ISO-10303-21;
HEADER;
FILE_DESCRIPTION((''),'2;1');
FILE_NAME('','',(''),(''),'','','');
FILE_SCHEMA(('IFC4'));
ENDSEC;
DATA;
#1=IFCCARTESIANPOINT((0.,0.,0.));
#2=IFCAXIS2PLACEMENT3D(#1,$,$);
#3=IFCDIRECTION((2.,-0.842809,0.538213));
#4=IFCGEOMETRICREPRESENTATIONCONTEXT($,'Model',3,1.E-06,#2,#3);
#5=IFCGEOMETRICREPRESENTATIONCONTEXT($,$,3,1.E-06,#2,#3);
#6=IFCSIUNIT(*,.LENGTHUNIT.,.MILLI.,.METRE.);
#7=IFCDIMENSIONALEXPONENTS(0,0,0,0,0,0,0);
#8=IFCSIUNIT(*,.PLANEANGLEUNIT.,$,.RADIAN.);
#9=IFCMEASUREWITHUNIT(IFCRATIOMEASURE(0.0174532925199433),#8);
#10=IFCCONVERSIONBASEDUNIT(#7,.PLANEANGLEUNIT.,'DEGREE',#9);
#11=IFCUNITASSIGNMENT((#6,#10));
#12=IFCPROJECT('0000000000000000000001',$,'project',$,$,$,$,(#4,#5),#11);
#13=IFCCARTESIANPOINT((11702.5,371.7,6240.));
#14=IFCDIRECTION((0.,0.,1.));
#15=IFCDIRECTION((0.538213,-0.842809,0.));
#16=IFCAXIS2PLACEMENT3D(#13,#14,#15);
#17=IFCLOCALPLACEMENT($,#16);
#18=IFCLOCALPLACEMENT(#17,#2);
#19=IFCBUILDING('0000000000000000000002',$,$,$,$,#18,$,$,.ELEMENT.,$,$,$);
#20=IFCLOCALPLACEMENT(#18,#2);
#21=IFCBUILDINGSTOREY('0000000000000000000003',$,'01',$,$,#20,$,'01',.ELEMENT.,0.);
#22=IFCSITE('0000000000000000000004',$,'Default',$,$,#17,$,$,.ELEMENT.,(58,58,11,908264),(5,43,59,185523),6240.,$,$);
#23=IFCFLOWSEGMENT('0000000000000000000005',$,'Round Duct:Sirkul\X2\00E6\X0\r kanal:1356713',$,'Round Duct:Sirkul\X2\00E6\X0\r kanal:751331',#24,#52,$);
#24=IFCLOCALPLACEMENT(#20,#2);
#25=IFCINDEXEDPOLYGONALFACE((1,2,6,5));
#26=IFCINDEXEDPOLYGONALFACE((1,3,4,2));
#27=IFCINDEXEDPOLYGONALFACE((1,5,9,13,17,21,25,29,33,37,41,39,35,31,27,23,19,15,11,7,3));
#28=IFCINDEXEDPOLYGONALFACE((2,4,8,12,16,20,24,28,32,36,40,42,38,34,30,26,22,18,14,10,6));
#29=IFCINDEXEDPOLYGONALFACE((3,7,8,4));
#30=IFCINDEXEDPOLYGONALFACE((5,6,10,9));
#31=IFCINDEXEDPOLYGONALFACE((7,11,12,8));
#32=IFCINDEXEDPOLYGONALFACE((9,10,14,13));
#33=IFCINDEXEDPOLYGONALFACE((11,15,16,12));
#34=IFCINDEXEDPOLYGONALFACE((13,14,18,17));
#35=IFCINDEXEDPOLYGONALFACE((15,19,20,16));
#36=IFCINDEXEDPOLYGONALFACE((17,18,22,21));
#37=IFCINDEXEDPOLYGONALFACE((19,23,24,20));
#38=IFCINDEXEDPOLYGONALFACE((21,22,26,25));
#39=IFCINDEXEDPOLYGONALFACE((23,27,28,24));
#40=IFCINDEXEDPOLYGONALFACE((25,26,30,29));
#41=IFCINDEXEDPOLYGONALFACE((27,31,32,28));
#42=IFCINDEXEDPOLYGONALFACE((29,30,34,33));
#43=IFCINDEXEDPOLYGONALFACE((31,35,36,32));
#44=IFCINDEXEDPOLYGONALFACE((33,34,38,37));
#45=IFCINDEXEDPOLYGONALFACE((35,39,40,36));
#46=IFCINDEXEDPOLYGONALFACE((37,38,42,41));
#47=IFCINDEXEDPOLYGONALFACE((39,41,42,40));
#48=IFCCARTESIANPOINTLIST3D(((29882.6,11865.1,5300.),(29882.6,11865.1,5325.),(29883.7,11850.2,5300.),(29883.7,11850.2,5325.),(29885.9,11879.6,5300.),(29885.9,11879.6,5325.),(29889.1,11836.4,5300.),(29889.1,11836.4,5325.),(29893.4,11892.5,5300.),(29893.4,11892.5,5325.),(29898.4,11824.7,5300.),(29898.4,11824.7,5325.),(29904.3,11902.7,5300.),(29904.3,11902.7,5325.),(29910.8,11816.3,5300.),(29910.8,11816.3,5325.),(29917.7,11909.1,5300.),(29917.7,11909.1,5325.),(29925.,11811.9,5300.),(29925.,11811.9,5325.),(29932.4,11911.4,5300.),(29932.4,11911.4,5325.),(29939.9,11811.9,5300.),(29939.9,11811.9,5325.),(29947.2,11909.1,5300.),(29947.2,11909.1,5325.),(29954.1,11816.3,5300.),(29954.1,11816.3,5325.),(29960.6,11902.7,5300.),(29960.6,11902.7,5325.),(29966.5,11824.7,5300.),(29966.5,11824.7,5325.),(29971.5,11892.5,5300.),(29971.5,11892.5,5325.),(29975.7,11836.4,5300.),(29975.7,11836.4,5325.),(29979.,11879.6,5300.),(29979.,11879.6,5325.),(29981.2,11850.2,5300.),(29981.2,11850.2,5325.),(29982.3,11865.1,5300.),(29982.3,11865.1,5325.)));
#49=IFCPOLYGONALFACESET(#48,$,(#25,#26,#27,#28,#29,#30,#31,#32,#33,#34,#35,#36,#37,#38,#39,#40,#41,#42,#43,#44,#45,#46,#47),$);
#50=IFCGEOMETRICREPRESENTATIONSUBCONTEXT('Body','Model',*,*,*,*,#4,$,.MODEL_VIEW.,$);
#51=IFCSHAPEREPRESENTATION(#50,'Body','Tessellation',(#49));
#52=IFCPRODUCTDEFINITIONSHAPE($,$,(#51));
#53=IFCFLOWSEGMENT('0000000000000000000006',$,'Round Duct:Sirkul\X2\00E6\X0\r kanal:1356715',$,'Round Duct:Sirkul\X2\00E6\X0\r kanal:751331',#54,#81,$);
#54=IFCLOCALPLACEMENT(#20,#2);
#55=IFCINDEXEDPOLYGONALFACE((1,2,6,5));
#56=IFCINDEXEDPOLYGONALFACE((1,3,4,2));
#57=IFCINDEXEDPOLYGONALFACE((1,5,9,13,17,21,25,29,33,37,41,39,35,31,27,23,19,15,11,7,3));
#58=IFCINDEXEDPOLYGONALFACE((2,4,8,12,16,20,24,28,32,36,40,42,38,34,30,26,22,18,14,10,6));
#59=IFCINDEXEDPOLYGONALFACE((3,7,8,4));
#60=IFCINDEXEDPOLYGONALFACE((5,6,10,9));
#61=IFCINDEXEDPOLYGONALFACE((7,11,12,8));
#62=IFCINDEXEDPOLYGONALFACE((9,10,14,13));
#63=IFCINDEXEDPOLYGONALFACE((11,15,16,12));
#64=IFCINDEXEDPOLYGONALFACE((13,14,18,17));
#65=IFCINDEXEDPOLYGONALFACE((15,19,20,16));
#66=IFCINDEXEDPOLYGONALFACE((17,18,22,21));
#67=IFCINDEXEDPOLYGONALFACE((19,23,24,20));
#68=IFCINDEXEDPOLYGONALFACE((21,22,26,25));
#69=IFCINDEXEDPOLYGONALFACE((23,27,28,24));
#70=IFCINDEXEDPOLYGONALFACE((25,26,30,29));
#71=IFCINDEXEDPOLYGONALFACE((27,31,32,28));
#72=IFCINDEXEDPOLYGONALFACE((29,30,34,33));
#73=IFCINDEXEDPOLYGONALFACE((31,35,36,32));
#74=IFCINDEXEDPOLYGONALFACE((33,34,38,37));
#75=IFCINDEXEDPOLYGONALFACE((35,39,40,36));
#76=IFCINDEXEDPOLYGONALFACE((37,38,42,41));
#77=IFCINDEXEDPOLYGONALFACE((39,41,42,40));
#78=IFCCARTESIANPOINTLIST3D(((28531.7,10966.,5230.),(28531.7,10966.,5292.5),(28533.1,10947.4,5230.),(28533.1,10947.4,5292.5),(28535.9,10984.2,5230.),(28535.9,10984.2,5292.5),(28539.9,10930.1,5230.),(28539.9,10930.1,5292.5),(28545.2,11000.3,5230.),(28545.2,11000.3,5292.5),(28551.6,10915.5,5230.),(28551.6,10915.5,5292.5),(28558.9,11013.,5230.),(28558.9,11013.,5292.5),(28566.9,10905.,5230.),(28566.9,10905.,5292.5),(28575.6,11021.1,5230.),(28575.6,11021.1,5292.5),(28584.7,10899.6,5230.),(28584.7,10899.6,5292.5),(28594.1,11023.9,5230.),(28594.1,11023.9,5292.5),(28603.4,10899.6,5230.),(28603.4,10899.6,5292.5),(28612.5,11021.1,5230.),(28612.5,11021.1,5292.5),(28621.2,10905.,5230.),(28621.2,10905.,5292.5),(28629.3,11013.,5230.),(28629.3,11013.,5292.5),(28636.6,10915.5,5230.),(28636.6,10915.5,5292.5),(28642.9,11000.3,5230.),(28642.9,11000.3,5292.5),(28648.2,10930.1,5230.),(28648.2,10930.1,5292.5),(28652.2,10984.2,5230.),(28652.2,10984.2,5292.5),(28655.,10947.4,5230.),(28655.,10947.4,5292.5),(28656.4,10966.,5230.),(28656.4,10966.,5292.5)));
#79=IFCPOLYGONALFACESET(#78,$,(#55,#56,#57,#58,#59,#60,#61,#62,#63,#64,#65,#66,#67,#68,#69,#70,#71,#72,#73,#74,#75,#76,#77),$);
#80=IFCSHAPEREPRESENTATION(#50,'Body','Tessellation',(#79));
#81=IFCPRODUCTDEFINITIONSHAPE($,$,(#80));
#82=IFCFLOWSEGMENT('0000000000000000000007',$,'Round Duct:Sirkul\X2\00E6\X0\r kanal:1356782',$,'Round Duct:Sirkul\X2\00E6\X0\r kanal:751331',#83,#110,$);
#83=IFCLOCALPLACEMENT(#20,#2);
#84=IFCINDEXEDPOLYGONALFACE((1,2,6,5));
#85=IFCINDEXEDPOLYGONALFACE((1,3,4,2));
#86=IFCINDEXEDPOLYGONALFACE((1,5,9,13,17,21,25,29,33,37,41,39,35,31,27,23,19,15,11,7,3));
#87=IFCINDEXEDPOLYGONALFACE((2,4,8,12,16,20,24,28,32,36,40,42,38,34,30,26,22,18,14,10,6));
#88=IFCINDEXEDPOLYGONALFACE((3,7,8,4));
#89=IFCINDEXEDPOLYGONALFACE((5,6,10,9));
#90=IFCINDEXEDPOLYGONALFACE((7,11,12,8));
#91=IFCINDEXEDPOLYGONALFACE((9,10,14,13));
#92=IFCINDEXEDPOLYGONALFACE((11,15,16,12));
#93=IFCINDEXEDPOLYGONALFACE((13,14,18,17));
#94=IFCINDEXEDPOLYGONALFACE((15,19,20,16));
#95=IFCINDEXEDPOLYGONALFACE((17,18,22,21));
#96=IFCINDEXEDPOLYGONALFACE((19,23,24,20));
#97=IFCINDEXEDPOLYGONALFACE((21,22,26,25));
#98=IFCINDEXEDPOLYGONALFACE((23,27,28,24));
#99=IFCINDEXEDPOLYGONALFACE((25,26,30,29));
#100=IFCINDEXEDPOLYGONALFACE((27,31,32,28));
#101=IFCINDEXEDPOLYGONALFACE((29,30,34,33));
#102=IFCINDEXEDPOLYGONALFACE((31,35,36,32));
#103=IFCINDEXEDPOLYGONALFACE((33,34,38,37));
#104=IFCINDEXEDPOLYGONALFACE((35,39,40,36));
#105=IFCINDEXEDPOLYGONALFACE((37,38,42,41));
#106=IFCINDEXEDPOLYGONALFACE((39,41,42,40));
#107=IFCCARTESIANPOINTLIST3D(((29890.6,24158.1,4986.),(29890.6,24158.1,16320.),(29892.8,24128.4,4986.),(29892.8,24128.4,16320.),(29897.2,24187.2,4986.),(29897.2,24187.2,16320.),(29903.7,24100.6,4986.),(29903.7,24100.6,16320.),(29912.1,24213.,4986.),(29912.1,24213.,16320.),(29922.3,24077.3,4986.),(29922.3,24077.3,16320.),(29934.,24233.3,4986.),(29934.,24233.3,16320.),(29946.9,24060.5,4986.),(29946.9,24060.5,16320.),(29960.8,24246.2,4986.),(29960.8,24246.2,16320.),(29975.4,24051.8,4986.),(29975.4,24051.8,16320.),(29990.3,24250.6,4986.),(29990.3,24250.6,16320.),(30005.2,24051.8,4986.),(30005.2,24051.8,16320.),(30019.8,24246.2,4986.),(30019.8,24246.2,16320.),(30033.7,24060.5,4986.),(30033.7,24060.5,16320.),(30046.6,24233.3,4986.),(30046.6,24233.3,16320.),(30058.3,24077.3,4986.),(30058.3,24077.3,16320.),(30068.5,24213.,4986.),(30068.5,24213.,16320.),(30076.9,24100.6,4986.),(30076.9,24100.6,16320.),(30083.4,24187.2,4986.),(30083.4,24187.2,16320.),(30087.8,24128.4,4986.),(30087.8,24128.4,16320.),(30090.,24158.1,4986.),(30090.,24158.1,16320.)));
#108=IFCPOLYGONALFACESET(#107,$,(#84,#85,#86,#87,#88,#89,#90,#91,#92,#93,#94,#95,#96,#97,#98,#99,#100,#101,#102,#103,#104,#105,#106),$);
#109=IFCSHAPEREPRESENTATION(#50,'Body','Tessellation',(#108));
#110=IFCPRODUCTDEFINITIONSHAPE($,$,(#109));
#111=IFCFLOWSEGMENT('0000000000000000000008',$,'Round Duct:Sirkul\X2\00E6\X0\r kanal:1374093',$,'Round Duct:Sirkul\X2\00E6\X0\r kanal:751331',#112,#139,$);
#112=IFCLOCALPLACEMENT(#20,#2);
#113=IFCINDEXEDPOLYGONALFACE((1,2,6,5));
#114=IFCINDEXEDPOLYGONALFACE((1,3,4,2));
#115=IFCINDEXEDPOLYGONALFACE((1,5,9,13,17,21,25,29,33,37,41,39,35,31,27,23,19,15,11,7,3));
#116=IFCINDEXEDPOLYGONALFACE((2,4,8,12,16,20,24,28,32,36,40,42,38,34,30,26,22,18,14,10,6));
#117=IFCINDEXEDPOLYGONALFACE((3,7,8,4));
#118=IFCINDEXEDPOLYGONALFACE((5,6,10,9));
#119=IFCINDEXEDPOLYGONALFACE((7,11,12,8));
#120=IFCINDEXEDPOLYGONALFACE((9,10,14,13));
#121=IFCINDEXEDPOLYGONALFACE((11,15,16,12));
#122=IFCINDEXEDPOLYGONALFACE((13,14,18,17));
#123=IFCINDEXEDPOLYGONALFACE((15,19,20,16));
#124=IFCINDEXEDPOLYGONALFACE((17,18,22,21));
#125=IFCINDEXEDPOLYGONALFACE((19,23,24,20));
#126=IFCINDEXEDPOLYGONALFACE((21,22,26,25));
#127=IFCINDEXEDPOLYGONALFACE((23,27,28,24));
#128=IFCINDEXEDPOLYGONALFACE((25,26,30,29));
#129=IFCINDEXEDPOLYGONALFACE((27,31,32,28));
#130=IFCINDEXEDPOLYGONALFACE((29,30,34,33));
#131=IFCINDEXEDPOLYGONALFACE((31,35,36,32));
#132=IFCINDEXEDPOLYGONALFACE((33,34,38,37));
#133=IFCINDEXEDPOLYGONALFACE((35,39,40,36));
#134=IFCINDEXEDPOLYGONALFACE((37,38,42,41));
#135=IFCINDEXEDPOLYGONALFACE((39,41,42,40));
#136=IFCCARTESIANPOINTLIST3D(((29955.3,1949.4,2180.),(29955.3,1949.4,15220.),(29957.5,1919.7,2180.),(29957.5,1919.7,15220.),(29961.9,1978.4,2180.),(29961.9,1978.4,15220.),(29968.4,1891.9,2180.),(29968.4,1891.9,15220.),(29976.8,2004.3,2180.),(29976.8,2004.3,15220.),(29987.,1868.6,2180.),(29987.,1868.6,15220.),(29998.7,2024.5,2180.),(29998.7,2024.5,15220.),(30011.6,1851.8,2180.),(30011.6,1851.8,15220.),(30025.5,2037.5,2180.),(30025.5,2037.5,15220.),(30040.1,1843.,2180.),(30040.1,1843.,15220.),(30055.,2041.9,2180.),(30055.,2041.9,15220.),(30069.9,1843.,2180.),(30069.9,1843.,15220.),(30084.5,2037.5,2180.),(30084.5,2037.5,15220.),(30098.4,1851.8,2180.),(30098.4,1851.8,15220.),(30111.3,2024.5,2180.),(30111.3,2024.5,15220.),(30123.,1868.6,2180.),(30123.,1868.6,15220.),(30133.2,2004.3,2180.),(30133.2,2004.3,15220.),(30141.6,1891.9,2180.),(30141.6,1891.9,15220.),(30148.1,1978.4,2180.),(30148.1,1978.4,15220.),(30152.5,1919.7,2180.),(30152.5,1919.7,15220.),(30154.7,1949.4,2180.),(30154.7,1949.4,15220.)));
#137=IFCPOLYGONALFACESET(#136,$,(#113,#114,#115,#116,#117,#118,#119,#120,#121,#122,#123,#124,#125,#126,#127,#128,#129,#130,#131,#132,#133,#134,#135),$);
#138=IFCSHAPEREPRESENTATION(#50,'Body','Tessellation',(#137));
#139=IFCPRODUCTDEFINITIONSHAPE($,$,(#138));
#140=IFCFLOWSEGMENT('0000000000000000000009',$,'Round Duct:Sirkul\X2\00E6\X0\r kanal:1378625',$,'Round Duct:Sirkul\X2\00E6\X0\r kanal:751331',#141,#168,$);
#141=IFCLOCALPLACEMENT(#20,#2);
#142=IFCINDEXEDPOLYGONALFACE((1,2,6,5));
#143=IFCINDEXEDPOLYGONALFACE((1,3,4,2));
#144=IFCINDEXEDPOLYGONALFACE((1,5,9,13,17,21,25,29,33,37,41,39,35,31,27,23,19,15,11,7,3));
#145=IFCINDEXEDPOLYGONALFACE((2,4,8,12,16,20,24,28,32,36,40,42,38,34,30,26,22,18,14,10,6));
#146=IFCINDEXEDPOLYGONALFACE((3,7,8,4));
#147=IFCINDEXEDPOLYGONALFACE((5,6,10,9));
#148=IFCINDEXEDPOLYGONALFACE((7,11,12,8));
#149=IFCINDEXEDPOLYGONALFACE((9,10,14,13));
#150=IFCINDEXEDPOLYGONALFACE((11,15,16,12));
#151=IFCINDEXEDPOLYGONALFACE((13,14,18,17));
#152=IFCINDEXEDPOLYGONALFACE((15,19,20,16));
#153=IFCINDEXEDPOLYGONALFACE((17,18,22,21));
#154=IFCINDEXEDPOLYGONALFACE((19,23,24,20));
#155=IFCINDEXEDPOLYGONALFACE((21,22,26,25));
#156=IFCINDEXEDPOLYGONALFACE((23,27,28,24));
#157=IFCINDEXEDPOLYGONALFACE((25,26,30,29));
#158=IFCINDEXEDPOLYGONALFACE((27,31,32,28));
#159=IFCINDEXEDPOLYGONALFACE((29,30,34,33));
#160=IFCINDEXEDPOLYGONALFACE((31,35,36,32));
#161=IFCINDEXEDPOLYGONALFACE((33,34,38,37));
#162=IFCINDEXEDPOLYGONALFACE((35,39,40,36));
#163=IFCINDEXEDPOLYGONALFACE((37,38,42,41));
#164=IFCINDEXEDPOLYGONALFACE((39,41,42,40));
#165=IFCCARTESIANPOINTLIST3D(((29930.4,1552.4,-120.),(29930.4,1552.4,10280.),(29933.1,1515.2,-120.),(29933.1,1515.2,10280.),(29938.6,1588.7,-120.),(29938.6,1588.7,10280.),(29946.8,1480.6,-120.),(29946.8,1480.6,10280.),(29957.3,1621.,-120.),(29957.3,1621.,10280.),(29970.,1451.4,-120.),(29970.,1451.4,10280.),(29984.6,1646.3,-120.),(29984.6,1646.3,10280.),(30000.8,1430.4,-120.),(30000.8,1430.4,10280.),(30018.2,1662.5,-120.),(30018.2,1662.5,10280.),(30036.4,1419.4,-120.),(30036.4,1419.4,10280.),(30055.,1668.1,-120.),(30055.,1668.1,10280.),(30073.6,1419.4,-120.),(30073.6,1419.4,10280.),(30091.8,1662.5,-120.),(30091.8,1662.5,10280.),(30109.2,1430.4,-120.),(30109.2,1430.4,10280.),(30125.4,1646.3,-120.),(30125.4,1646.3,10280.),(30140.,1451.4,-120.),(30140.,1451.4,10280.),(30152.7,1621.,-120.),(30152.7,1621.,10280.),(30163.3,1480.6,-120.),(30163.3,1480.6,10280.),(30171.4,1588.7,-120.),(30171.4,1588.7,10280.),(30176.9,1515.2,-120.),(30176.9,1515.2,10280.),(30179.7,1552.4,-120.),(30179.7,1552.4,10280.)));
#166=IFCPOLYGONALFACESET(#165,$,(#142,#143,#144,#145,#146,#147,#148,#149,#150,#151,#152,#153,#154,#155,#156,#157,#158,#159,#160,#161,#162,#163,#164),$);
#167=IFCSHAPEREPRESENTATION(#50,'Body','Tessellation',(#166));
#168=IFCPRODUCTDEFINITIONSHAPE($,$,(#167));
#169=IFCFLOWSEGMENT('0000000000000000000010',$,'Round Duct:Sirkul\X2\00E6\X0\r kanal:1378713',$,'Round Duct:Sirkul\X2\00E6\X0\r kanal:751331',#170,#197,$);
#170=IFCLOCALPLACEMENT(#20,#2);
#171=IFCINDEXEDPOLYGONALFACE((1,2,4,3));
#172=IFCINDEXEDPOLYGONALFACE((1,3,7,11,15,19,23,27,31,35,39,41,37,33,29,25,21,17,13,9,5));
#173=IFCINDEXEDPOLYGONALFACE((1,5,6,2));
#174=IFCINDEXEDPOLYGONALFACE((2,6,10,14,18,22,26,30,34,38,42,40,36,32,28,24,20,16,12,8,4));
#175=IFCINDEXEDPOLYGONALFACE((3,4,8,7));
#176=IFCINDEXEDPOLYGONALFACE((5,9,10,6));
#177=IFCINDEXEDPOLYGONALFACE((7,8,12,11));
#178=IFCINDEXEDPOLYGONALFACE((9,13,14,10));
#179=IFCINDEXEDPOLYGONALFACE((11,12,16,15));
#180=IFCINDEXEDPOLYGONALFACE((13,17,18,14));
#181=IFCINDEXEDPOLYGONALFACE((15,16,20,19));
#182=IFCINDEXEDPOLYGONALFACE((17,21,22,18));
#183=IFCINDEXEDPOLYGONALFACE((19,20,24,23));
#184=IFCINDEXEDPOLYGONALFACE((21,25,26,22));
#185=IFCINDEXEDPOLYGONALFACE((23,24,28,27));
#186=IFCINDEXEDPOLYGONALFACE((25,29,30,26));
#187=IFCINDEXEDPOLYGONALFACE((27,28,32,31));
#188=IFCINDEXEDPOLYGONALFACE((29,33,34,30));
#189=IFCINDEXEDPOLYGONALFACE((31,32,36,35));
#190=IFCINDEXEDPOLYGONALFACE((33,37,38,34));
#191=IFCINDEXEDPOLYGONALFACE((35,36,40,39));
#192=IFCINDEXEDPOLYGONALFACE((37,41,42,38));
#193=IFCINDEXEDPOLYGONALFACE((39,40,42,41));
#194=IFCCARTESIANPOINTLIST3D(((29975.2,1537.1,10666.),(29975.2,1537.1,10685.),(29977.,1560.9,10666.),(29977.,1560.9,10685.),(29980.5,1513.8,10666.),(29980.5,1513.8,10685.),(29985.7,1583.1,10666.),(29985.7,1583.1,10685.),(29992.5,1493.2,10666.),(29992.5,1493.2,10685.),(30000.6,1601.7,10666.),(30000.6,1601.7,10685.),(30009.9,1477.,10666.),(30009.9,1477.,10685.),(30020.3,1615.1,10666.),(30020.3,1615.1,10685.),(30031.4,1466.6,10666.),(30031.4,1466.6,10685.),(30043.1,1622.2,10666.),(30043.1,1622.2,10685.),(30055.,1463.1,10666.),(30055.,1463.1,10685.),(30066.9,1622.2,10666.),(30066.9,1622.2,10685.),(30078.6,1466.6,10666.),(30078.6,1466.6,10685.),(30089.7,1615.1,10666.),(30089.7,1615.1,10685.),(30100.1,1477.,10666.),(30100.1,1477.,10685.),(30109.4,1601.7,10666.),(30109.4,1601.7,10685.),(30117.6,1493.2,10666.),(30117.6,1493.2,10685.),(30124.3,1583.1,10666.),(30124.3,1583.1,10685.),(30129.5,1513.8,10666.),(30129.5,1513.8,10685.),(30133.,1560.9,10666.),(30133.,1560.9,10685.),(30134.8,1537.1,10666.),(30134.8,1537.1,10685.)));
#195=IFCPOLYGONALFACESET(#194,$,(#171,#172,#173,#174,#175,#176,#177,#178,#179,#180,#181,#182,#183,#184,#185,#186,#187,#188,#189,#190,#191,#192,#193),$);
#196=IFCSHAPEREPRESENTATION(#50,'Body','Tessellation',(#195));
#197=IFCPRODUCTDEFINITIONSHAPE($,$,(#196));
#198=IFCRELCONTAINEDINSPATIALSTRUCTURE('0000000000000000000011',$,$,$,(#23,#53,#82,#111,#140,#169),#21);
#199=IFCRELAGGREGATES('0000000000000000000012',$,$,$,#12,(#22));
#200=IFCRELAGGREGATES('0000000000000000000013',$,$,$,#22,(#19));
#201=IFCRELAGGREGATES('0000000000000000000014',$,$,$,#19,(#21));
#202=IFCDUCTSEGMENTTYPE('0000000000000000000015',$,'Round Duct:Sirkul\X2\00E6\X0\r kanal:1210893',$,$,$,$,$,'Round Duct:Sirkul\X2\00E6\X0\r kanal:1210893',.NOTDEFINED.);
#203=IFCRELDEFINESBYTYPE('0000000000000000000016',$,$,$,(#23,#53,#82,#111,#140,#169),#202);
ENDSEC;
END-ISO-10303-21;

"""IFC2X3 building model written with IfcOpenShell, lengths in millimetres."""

from ifc_helpers import new_model, entity, si_unit, converted_unit, direction, frame, frame_2d, origin, origin_2d_with_axis, place, context, subcontext, project, spatial, circle, extrude, type_object, element, save


model = new_model("IFC2X3")

# Units and contexts
model_context = context("Model", 3, precision=1e-06, world=origin(), true_north=direction((2.0, -0.842809, 0.538213)))
context_of_model = context(None, 3, precision=1e-06, world=origin(), true_north=direction((2.0, -0.842809, 0.538213)))
body_context = subcontext(model_context, "Body", "Model", "MODEL_VIEW")
ifc_project = project(units=[si_unit("LENGTHUNIT", "METRE", prefix="MILLI"), converted_unit("PLANEANGLEUNIT", "DEGREE", entity("IfcRatioMeasure", 0.0174532925199433), si_unit("PLANEANGLEUNIT", "RADIAN"), dimensions=[0, 0, 0, 0, 0, 0, 0])], contexts=[model_context, context_of_model])

# Site, building, storey
site_placement = place(None, frame((11702.5, 371.7, 6240.0), z_axis=(0.0, 0.0, 1.0), x_axis=(0.538213, -0.842809, 0.0)))
site = spatial("IfcSite", under=ifc_project, at=site_placement, Name="Default", CompositionType="ELEMENT", RefLatitude=(58, 58, 11, 908264), RefLongitude=(5, 43, 59, 185523), RefElevation=6240.0)
building_placement = place(site_placement, origin())
building = spatial("IfcBuilding", under=site, at=building_placement, CompositionType="ELEMENT")
storey_placement = place(building_placement, origin())
storey = spatial("IfcBuildingStorey", under=building, at=storey_placement, Name="01", LongName="01", CompositionType="ELEMENT", Elevation=0.0)

# Flow segments
duct_segment_type = type_object("IfcDuctSegmentType", Name="Round Duct:Sirkulær kanal:1210893", ElementType="Round Duct:Sirkulær kanal:1210893", PredefinedType="NOTDEFINED")
flow_segment_1_placement = place(storey_placement, origin())
element("IfcFlowSegment", 1, at=flow_segment_1_placement, inside=storey, type_object=duct_segment_type, Name="Round Duct:Sirkulær kanal:1356713", ObjectType="Round Duct:Sirkulær kanal:751331", context=body_context, shape_type="SweptSolid", body=[
    extrude(circle(Radius=50.0, at=frame_2d((0.0, 0.0), x_axis=(1.0, 0.0))), frame((29932.4, 11861.4, 5300.0), z_axis=(0.0, 0.0, 1.0), x_axis=(0.0, 1.0, 0.0)), (0.0, 0.0, 1.0), 25.0),
])
flow_segment_2_placement = place(storey_placement, origin())
element("IfcFlowSegment", 2, at=flow_segment_2_placement, inside=storey, type_object=duct_segment_type, Name="Round Duct:Sirkulær kanal:1356715", ObjectType="Round Duct:Sirkulær kanal:751331", context=body_context, shape_type="SweptSolid", body=[
    extrude(circle(Radius=62.5, at=frame_2d((0.0, 0.0), x_axis=(1.0, 0.0))), frame((28594.1, 10961.4, 5230.0), z_axis=(0.0, 0.0, 1.0), x_axis=(0.0, 1.0, 0.0)), (0.0, 0.0, 1.0), 62.5),
])
flow_segment_3_placement = place(storey_placement, origin())
element("IfcFlowSegment", 3, at=flow_segment_3_placement, inside=storey, type_object=duct_segment_type, Name="Round Duct:Sirkulær kanal:1356782", ObjectType="Round Duct:Sirkulær kanal:751331", context=body_context, shape_type="SweptSolid", body=[
    extrude(circle(Radius=100.0, at=origin_2d_with_axis()), frame((29990.3, 24150.6, 4986.0), z_axis=(0.0, 0.0, 1.0), x_axis=(0.0, 1.0, 0.0)), (0.0, 0.0, 1.0), 11334.0),
])
flow_segment_4_placement = place(storey_placement, origin())
element("IfcFlowSegment", 4, at=flow_segment_4_placement, inside=storey, type_object=duct_segment_type, Name="Round Duct:Sirkulær kanal:1374093", ObjectType="Round Duct:Sirkulær kanal:751331", context=body_context, shape_type="SweptSolid", body=[
    extrude(circle(Radius=100.0, at=frame_2d((0.0, 0.0), x_axis=(1.0, 0.0))), frame((30055.0, 1941.9, 2180.0), z_axis=(0.0, 0.0, 1.0), x_axis=(0.0, 1.0, 0.0)), (0.0, 0.0, 1.0), 13040.0),
])
flow_segment_5_placement = place(storey_placement, origin())
element("IfcFlowSegment", 5, at=flow_segment_5_placement, inside=storey, type_object=duct_segment_type, Name="Round Duct:Sirkulær kanal:1378625", ObjectType="Round Duct:Sirkulær kanal:751331", context=body_context, shape_type="SweptSolid", body=[
    extrude(circle(Radius=125.0, at=origin_2d_with_axis()), frame((30055.0, 1543.1, -120.0), z_axis=(0.0, 0.0, 1.0), x_axis=(0.0, 1.0, 0.0)), (0.0, 0.0, 1.0), 10400.0),
])
flow_segment_6_placement = place(storey_placement, origin())
element("IfcFlowSegment", 6, at=flow_segment_6_placement, inside=storey, type_object=duct_segment_type, Name="Round Duct:Sirkulær kanal:1378713", ObjectType="Round Duct:Sirkulær kanal:751331", context=body_context, shape_type="SweptSolid", body=[
    extrude(circle(Radius=80.0, at=origin_2d_with_axis()), frame((30055.0, 1543.1, 10666.0), z_axis=(0.0, 0.0, 1.0), x_axis=(0.0, -1.0, 0.0)), (0.0, 0.0, 1.0), 19.0),
])

save(model, "model.ifc")
